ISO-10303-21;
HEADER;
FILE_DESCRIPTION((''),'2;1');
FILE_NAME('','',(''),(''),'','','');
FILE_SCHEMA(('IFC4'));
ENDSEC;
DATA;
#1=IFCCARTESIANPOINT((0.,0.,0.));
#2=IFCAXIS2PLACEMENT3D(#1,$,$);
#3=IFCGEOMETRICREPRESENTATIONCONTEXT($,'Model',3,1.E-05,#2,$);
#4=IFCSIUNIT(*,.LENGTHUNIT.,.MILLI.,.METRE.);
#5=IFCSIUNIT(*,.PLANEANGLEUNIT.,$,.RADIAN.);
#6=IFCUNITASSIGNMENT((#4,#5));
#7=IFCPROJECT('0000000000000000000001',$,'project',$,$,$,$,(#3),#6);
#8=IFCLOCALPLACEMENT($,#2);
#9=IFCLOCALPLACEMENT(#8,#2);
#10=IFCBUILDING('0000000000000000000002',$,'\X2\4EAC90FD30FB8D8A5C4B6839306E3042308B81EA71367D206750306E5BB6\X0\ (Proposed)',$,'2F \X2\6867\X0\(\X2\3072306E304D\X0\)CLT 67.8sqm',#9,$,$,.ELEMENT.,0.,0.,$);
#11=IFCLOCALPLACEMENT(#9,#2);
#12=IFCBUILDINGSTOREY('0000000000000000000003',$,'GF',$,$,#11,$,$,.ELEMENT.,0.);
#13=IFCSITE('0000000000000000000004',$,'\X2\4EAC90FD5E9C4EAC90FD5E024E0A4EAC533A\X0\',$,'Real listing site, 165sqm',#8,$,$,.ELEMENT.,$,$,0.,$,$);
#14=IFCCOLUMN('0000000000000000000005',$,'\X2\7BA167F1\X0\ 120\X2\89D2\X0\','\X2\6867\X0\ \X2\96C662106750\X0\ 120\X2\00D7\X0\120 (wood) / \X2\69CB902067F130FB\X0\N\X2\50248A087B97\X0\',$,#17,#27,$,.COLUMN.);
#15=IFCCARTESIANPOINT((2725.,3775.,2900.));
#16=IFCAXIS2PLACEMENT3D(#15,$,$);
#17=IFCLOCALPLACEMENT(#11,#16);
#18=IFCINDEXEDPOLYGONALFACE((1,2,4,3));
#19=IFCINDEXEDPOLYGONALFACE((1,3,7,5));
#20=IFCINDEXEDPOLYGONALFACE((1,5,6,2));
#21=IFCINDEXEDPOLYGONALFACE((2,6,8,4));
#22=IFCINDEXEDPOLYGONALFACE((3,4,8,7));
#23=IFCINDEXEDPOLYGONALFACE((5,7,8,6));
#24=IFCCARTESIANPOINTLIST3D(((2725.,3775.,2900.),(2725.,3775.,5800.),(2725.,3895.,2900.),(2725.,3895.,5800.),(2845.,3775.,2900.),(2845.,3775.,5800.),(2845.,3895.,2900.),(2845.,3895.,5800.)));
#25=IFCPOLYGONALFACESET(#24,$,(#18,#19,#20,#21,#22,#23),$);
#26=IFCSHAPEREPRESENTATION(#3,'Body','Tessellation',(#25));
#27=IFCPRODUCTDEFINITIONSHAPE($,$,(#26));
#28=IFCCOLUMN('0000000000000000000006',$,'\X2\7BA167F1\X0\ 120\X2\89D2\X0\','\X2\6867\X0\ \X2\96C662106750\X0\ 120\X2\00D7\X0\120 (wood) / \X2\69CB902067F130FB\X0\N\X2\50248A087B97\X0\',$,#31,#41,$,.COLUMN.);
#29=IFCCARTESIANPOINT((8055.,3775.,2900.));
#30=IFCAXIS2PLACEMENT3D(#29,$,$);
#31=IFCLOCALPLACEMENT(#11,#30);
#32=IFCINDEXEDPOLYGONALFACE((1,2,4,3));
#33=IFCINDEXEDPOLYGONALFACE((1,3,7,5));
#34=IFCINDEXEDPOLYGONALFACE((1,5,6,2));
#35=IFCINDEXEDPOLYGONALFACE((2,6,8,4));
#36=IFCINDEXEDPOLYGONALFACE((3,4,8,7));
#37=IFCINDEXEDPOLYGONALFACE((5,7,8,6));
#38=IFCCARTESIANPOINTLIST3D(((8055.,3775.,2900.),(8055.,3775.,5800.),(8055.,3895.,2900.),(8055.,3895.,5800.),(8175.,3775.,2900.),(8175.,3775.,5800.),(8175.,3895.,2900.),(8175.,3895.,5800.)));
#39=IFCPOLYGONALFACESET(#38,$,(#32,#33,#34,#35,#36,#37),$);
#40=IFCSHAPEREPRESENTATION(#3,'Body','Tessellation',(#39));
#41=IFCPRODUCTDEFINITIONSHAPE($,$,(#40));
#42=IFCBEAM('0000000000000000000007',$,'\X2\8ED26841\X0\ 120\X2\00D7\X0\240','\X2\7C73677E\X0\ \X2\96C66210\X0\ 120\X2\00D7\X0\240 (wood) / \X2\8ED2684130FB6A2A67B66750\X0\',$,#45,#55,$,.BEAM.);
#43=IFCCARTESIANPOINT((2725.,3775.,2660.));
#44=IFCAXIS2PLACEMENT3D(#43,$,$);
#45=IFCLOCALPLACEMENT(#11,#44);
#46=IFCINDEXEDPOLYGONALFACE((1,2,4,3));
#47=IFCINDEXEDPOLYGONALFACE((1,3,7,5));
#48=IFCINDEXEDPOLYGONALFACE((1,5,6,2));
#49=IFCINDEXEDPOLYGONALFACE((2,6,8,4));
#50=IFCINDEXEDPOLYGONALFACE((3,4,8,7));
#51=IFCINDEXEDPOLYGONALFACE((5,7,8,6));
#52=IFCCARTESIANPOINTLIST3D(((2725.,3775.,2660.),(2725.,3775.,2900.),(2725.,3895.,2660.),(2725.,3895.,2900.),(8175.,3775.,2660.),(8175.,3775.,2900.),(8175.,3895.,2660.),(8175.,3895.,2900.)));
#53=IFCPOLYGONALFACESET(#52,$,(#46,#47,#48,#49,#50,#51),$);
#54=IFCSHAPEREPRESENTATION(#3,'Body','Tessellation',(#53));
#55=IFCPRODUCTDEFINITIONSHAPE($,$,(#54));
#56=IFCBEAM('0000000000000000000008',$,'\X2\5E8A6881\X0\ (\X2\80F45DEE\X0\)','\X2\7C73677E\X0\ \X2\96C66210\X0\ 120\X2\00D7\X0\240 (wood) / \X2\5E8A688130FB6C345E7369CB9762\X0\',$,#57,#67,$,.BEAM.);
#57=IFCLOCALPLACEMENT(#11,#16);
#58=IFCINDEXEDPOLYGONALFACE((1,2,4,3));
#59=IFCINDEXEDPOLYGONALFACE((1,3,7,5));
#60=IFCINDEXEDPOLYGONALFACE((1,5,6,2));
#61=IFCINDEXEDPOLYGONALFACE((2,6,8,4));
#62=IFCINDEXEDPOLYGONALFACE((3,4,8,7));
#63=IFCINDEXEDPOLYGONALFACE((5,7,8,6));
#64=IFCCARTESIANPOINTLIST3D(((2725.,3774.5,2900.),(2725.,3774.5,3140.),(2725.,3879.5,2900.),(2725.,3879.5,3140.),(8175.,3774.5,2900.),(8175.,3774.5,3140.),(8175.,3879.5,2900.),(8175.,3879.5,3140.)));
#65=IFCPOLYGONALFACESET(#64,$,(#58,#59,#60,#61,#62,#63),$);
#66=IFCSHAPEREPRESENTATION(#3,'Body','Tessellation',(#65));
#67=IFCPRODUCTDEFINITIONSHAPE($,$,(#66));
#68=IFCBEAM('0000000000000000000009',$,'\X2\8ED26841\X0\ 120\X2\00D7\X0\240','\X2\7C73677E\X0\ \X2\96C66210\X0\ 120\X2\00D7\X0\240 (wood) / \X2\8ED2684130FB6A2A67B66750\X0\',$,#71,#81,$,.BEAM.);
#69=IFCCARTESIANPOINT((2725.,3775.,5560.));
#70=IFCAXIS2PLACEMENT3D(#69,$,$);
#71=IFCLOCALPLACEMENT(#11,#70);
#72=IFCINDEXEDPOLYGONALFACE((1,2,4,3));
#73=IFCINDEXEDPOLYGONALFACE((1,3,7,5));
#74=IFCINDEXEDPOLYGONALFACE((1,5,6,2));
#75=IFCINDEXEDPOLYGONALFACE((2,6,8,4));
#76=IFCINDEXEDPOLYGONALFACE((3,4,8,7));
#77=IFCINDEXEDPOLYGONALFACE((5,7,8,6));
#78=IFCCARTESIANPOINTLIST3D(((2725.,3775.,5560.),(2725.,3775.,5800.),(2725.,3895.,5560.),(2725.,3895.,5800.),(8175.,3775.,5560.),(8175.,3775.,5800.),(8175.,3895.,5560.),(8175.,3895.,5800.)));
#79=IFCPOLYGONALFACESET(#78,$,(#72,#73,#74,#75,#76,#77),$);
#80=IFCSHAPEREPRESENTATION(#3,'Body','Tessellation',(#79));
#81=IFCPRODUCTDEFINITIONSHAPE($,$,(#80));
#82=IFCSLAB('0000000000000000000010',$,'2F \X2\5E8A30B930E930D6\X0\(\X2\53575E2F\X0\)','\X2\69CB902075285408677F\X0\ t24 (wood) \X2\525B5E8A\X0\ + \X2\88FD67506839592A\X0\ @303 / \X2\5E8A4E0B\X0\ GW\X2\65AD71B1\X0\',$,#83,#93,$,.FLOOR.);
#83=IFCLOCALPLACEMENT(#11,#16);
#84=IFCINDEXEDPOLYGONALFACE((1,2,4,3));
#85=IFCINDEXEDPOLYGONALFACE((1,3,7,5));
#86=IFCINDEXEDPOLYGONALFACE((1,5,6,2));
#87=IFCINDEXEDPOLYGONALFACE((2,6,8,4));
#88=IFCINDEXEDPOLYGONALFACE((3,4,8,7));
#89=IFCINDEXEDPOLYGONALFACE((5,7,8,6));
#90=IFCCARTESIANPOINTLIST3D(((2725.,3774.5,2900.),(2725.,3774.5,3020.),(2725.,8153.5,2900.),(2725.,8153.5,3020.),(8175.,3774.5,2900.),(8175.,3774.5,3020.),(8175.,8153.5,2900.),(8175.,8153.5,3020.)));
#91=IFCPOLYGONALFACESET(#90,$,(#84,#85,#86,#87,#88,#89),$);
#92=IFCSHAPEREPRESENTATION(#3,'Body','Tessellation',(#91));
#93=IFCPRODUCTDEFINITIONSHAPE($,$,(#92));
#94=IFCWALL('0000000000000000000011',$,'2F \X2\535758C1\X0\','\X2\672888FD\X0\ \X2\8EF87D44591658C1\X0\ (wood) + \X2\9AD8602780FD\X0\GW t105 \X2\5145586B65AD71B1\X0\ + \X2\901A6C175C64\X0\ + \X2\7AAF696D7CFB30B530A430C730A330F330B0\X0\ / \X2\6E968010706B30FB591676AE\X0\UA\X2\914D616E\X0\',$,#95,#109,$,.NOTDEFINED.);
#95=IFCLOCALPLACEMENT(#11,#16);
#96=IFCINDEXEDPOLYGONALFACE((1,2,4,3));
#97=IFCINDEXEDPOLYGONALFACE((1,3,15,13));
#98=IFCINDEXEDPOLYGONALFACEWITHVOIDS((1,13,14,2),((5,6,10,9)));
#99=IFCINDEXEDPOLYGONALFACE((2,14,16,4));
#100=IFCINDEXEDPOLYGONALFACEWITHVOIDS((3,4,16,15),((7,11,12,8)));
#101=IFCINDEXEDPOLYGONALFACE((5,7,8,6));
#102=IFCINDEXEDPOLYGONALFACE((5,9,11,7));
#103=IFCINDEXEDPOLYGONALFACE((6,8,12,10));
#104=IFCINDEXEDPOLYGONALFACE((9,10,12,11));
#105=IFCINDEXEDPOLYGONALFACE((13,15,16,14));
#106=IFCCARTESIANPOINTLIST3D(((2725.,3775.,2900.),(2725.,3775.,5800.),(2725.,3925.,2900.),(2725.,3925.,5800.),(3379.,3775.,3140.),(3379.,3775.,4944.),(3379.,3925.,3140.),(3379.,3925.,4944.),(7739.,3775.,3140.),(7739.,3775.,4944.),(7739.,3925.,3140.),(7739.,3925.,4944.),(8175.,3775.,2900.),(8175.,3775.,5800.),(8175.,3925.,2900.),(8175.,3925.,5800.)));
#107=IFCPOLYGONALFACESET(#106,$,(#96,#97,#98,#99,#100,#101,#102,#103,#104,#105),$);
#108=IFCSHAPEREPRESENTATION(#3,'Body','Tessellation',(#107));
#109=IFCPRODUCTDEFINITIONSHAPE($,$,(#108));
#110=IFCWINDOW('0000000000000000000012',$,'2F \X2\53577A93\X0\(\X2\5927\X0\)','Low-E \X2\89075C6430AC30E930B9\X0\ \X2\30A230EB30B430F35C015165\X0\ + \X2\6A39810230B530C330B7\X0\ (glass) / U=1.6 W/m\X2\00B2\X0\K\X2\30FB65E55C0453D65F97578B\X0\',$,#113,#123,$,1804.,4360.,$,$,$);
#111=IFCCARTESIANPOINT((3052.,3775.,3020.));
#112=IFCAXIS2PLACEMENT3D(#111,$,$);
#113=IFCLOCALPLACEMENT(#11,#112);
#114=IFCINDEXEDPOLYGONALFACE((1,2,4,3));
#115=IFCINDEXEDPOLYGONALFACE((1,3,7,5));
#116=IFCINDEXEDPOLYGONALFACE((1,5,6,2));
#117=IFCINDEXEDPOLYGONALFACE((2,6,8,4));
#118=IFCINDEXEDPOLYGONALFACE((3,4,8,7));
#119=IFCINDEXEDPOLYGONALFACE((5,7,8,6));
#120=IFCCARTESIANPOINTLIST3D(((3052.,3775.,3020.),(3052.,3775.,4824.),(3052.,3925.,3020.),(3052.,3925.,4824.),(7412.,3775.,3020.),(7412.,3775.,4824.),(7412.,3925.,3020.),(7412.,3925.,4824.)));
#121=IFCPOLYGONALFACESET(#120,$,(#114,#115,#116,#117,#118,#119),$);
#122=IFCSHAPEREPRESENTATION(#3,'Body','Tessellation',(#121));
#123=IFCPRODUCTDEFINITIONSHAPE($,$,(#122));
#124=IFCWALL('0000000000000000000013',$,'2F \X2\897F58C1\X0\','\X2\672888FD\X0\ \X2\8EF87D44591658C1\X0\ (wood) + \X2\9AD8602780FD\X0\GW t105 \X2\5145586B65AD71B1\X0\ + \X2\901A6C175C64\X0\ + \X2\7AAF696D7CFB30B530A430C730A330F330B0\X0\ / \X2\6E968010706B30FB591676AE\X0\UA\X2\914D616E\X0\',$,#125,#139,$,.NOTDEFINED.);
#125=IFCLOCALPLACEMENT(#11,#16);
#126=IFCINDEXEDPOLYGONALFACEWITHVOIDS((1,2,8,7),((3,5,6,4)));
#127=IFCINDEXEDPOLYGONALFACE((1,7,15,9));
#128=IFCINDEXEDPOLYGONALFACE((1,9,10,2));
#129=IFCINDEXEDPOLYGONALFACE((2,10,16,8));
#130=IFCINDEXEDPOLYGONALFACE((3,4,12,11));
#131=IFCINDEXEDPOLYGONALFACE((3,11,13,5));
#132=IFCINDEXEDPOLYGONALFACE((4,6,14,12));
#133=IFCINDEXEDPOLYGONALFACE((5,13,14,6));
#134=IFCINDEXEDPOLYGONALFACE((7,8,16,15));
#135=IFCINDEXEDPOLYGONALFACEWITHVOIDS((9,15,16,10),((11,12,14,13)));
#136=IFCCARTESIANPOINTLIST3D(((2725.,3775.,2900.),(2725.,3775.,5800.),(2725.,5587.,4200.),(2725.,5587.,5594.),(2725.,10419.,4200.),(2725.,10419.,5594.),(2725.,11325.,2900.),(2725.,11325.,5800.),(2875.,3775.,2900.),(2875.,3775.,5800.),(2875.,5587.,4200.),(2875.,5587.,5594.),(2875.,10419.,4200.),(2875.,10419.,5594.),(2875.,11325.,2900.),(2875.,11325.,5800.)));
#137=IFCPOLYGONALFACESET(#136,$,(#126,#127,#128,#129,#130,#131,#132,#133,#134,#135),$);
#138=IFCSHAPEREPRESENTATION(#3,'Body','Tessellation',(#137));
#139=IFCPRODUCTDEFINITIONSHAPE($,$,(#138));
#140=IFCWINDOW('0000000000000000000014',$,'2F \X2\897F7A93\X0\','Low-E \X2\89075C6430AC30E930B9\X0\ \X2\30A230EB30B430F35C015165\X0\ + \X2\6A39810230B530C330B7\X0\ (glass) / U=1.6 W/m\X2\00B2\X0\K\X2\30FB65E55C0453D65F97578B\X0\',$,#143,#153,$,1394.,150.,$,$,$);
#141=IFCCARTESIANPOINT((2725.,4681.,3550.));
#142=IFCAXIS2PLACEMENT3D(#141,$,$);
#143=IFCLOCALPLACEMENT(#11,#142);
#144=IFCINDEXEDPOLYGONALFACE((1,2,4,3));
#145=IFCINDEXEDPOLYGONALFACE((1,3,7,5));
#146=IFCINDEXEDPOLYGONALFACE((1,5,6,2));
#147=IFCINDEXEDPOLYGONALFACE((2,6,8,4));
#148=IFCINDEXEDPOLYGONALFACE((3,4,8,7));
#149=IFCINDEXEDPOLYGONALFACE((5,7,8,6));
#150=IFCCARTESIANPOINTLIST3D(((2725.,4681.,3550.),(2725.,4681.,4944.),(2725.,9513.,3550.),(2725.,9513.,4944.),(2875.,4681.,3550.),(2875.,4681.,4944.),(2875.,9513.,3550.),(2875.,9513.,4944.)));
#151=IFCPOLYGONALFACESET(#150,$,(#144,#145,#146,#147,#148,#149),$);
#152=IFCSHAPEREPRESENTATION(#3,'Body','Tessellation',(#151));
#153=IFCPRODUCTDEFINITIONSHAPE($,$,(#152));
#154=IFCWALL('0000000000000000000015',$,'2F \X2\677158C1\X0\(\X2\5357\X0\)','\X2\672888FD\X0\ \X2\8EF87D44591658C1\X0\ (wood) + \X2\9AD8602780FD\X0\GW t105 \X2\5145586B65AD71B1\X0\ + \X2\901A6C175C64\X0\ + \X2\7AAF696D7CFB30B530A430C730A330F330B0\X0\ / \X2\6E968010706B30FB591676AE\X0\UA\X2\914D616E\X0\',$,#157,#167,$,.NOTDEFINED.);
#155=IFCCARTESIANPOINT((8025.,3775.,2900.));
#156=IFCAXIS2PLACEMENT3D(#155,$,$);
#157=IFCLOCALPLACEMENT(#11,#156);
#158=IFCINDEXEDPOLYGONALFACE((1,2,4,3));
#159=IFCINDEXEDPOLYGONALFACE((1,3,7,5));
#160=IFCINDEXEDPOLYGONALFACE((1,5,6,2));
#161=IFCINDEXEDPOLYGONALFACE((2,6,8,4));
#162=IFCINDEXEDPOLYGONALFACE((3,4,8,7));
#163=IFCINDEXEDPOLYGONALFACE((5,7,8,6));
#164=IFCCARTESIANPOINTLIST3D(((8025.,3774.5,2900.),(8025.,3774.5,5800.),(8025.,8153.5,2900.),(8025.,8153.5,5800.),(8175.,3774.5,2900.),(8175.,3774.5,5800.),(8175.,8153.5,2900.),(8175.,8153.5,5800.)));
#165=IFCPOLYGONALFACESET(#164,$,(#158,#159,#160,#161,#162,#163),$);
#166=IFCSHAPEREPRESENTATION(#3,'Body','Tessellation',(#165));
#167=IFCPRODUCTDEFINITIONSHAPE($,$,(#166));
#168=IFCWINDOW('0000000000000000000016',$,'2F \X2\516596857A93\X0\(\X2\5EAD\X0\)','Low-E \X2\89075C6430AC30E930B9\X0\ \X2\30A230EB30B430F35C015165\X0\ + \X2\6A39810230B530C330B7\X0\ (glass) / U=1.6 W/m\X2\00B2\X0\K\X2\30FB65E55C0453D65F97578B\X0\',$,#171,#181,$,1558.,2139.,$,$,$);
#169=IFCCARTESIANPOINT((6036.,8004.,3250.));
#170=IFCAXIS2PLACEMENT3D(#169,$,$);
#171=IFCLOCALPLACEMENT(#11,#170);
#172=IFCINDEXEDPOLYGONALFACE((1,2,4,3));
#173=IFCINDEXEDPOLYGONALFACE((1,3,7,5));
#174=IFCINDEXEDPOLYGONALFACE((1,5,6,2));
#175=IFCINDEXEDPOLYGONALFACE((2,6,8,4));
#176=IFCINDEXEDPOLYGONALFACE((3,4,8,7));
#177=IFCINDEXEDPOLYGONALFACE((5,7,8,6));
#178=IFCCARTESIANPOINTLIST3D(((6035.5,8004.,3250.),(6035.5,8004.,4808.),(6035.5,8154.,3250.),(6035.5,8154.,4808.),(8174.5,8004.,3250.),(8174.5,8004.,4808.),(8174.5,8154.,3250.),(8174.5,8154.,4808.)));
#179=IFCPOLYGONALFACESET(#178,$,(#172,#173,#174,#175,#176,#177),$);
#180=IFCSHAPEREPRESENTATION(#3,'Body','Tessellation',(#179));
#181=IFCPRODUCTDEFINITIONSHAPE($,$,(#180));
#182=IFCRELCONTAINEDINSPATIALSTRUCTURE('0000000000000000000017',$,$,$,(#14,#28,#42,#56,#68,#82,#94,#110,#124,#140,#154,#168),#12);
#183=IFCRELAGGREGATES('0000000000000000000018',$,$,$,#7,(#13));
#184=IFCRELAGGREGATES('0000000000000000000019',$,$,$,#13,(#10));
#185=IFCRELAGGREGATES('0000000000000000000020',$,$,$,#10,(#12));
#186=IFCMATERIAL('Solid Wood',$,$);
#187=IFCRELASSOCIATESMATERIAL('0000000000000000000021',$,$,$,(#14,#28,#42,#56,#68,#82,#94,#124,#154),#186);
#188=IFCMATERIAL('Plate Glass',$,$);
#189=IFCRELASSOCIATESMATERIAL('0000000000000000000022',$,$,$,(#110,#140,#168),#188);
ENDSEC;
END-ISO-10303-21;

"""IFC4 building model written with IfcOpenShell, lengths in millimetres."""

from ifc_helpers import new_model, si_unit, frame, frame_2d, origin, place, context, project, spatial, rectangle, extrude, material, element, fill, save


model = new_model("IFC4")

# Units and contexts
model_context = context("Model", 3, precision=1e-05, world=origin())
ifc_project = project(units=[si_unit("LENGTHUNIT", "METRE", prefix="MILLI"), si_unit("PLANEANGLEUNIT", "RADIAN")], contexts=[model_context])

# Site, building, storey
site_placement = place(None, origin())
site = spatial("IfcSite", under=ifc_project, at=site_placement, Name="京都府京都市上京区", ObjectType="Real listing site, 165sqm", CompositionType="ELEMENT", RefElevation=0.0)
building_placement = place(site_placement, origin())
building = spatial("IfcBuilding", under=site, at=building_placement, Name="京都・越屋根のある自然素材の家 (Proposed)", ObjectType="2F 桧(ひのき)CLT 67.8sqm", CompositionType="ELEMENT", ElevationOfRefHeight=0.0, ElevationOfTerrain=0.0)
storey_placement = place(building_placement, origin())
storey = spatial("IfcBuildingStorey", under=building, at=storey_placement, Name="GF", CompositionType="ELEMENT", Elevation=0.0)

# Columns
ifc_material_1 = material(Name="Solid Wood")
column_1_placement = place(storey_placement, frame((2725.0, 3775.0, 2900.0)))
element("IfcColumn", 1, at=column_1_placement, inside=storey, material=ifc_material_1, Name="管柱 120角", Description="桧 集成材 120×120 (wood) / 構造柱・N値計算", PredefinedType="COLUMN", context=model_context, shape_type="SweptSolid", body=[
    extrude(rectangle(XDim=120.0, YDim=120.0, at=frame_2d((60.0, 60.0))), frame((2725.0, 3775.0, 2900.0)), (0.0, 0.0, 1.0), 2900.0),
])
column_2_placement = place(storey_placement, frame((8055.0, 3775.0, 2900.0)))
element("IfcColumn", 2, at=column_2_placement, inside=storey, material=ifc_material_1, Name="管柱 120角", Description="桧 集成材 120×120 (wood) / 構造柱・N値計算", PredefinedType="COLUMN", context=model_context, shape_type="SweptSolid", body=[
    extrude(rectangle(XDim=120.0, YDim=120.0, at=frame_2d((60.0, 60.0))), frame((8055.0, 3775.0, 2900.0)), (0.0, 0.0, 1.0), 2900.0),
])

# Beams
beam_1_placement = place(storey_placement, frame((2725.0, 3775.0, 2660.0)))
element("IfcBeam", 3, at=beam_1_placement, inside=storey, material=ifc_material_1, Name="軒桁 120×240", Description="米松 集成 120×240 (wood) / 軒桁・横架材", PredefinedType="BEAM", context=model_context, shape_type="SweptSolid", body=[
    extrude(rectangle(XDim=5450.0, YDim=120.0, at=frame_2d((2725.0, 60.0))), frame((2725.0, 3775.0, 2660.0)), (0.0, 0.0, 1.0), 240.0),
])
beam_2_placement = place(storey_placement, frame((2725.0, 3775.0, 2900.0)))
element("IfcBeam", 4, at=beam_2_placement, inside=storey, material=ifc_material_1, Name="床梁 (胴差)", Description="米松 集成 120×240 (wood) / 床梁・水平構面", PredefinedType="BEAM", context=model_context, shape_type="SweptSolid", body=[
    extrude(rectangle(XDim=5450.0, YDim=105.0, at=frame_2d((2725.0, 52.0))), frame((2725.0, 3775.0, 2900.0)), (0.0, 0.0, 1.0), 240.0),
])
beam_3_placement = place(storey_placement, frame((2725.0, 3775.0, 5560.0)))
element("IfcBeam", 5, at=beam_3_placement, inside=storey, material=ifc_material_1, Name="軒桁 120×240", Description="米松 集成 120×240 (wood) / 軒桁・横架材", PredefinedType="BEAM", context=model_context, shape_type="SweptSolid", body=[
    extrude(rectangle(XDim=5450.0, YDim=120.0, at=frame_2d((2725.0, 60.0))), frame((2725.0, 3775.0, 5560.0)), (0.0, 0.0, 1.0), 240.0),
])

# Slab
slab_placement = place(storey_placement, frame((2725.0, 3775.0, 2900.0)))
element("IfcSlab", 6, at=slab_placement, inside=storey, material=ifc_material_1, Name="2F 床スラブ(南帯)", Description="構造用合板 t24 (wood) 剛床 + 製材根太 @303 / 床下 GW断熱", PredefinedType="FLOOR", context=model_context, shape_type="SweptSolid", body=[
    extrude(rectangle(XDim=5450.0, YDim=4379.0, at=frame_2d((2725.0, 2189.0))), frame((2725.0, 3775.0, 2900.0)), (0.0, 0.0, 1.0), 120.0),
])

# Walls, openings, windows
wall_1_placement = place(storey_placement, frame((2725.0, 3775.0, 2900.0)))
wall_1 = element("IfcWall", 7, at=wall_1_placement, inside=storey, material=ifc_material_1, Name="2F 南壁", Description="木製 軸組外壁 (wood) + 高性能GW t105 充填断熱 + 通気層 + 窯業系サイディング / 準耐火・外皮UA配慮", PredefinedType="NOTDEFINED", context=model_context, shape_type="SweptSolid", body=[
    extrude(rectangle(XDim=5450.0, YDim=150.0, at=frame_2d((2725.0, 75.0))), frame((2725.0, 3775.0, 2900.0)), (0.0, 0.0, 1.0), 2900.0),
])
opening_1_placement = place(storey_placement, frame((3052.0, 3775.0, 3020.0)))
opening_1 = element("IfcOpeningElement", 8, at=opening_1_placement, cuts=wall_1, PredefinedType="NOTDEFINED", context=model_context, shape_type="SweptSolid", body=[
    extrude(rectangle(XDim=4360.0, YDim=150.0, at=frame_2d((2180.0, 75.0))), frame((3052.0, 3775.0, 3020.0)), (0.0, 0.0, 1.0), 1804.0),
])
ifc_material_2 = material(Name="Plate Glass")
window_1_placement = place(storey_placement, frame((3052.0, 3775.0, 3020.0)))
window_1 = element("IfcWindow", 9, at=window_1_placement, inside=storey, material=ifc_material_2, Name="2F 南窓(大)", Description="Low-E 複層ガラス アルゴン封入 + 樹脂サッシ (glass) / U=1.6 W/m²K・日射取得型", OverallHeight=1804.0, OverallWidth=4360.0, context=model_context, shape_type="SweptSolid", body=[
    extrude(rectangle(XDim=4360.0, YDim=150.0, at=frame_2d((2180.0, 75.0))), frame((3052.0, 3775.0, 3020.0)), (0.0, 0.0, 1.0), 1804.0),
])
fill(opening_1, window_1)
wall_2_placement = place(storey_placement, frame((2725.0, 3775.0, 2900.0)))
wall_2 = element("IfcWall", 10, at=wall_2_placement, inside=storey, material=ifc_material_1, Name="2F 西壁", Description="木製 軸組外壁 (wood) + 高性能GW t105 充填断熱 + 通気層 + 窯業系サイディング / 準耐火・外皮UA配慮", PredefinedType="NOTDEFINED", context=model_context, shape_type="SweptSolid", body=[
    extrude(rectangle(XDim=150.0, YDim=7550.0, at=frame_2d((75.0, 3775.0))), frame((2725.0, 3775.0, 2900.0)), (0.0, 0.0, 1.0), 2900.0),
])
opening_2_placement = place(storey_placement, frame((2725.0, 4681.0, 3550.0)))
opening_2 = element("IfcOpeningElement", 11, at=opening_2_placement, cuts=wall_2, PredefinedType="NOTDEFINED", context=model_context, shape_type="SweptSolid", body=[
    extrude(rectangle(XDim=150.0, YDim=4832.0, at=frame_2d((75.0, 2416.0))), frame((2725.0, 4681.0, 3550.0)), (0.0, 0.0, 1.0), 1394.0),
])
window_2_placement = place(storey_placement, frame((2725.0, 4681.0, 3550.0)))
window_2 = element("IfcWindow", 12, at=window_2_placement, inside=storey, material=ifc_material_2, Name="2F 西窓", Description="Low-E 複層ガラス アルゴン封入 + 樹脂サッシ (glass) / U=1.6 W/m²K・日射取得型", OverallHeight=1394.0, OverallWidth=150.0, context=model_context, shape_type="SweptSolid", body=[
    extrude(rectangle(XDim=150.0, YDim=4832.0, at=frame_2d((75.0, 2416.0))), frame((2725.0, 4681.0, 3550.0)), (0.0, 0.0, 1.0), 1394.0),
])
fill(opening_2, window_2)
wall_3_placement = place(storey_placement, frame((8025.0, 3775.0, 2900.0)))
wall_3 = element("IfcWall", 13, at=wall_3_placement, inside=storey, material=ifc_material_1, Name="2F 東壁(南)", Description="木製 軸組外壁 (wood) + 高性能GW t105 充填断熱 + 通気層 + 窯業系サイディング / 準耐火・外皮UA配慮", PredefinedType="NOTDEFINED", context=model_context, shape_type="SweptSolid", body=[
    extrude(rectangle(XDim=150.0, YDim=4379.0, at=frame_2d((75.0, 2189.0))), frame((8025.0, 3775.0, 2900.0)), (0.0, 0.0, 1.0), 2900.0),
])
opening_3_placement = place(storey_placement, frame((6036.0, 8004.0, 3250.0)))
opening_3 = element("IfcOpeningElement", 14, at=opening_3_placement, cuts=wall_3, PredefinedType="NOTDEFINED", context=model_context, shape_type="SweptSolid", body=[
    extrude(rectangle(XDim=2139.0, YDim=150.0, at=frame_2d((1069.0, 75.0))), frame((6036.0, 8004.0, 3250.0)), (0.0, 0.0, 1.0), 1558.0),
])
window_3_placement = place(storey_placement, frame((6036.0, 8004.0, 3250.0)))
window_3 = element("IfcWindow", 15, at=window_3_placement, inside=storey, material=ifc_material_2, Name="2F 入隅窓(庭)", Description="Low-E 複層ガラス アルゴン封入 + 樹脂サッシ (glass) / U=1.6 W/m²K・日射取得型", OverallHeight=1558.0, OverallWidth=2139.0, context=model_context, shape_type="SweptSolid", body=[
    extrude(rectangle(XDim=2139.0, YDim=150.0, at=frame_2d((1069.0, 75.0))), frame((6036.0, 8004.0, 3250.0)), (0.0, 0.0, 1.0), 1558.0),
])
fill(opening_3, window_3)

save(model, "model.ifc")
